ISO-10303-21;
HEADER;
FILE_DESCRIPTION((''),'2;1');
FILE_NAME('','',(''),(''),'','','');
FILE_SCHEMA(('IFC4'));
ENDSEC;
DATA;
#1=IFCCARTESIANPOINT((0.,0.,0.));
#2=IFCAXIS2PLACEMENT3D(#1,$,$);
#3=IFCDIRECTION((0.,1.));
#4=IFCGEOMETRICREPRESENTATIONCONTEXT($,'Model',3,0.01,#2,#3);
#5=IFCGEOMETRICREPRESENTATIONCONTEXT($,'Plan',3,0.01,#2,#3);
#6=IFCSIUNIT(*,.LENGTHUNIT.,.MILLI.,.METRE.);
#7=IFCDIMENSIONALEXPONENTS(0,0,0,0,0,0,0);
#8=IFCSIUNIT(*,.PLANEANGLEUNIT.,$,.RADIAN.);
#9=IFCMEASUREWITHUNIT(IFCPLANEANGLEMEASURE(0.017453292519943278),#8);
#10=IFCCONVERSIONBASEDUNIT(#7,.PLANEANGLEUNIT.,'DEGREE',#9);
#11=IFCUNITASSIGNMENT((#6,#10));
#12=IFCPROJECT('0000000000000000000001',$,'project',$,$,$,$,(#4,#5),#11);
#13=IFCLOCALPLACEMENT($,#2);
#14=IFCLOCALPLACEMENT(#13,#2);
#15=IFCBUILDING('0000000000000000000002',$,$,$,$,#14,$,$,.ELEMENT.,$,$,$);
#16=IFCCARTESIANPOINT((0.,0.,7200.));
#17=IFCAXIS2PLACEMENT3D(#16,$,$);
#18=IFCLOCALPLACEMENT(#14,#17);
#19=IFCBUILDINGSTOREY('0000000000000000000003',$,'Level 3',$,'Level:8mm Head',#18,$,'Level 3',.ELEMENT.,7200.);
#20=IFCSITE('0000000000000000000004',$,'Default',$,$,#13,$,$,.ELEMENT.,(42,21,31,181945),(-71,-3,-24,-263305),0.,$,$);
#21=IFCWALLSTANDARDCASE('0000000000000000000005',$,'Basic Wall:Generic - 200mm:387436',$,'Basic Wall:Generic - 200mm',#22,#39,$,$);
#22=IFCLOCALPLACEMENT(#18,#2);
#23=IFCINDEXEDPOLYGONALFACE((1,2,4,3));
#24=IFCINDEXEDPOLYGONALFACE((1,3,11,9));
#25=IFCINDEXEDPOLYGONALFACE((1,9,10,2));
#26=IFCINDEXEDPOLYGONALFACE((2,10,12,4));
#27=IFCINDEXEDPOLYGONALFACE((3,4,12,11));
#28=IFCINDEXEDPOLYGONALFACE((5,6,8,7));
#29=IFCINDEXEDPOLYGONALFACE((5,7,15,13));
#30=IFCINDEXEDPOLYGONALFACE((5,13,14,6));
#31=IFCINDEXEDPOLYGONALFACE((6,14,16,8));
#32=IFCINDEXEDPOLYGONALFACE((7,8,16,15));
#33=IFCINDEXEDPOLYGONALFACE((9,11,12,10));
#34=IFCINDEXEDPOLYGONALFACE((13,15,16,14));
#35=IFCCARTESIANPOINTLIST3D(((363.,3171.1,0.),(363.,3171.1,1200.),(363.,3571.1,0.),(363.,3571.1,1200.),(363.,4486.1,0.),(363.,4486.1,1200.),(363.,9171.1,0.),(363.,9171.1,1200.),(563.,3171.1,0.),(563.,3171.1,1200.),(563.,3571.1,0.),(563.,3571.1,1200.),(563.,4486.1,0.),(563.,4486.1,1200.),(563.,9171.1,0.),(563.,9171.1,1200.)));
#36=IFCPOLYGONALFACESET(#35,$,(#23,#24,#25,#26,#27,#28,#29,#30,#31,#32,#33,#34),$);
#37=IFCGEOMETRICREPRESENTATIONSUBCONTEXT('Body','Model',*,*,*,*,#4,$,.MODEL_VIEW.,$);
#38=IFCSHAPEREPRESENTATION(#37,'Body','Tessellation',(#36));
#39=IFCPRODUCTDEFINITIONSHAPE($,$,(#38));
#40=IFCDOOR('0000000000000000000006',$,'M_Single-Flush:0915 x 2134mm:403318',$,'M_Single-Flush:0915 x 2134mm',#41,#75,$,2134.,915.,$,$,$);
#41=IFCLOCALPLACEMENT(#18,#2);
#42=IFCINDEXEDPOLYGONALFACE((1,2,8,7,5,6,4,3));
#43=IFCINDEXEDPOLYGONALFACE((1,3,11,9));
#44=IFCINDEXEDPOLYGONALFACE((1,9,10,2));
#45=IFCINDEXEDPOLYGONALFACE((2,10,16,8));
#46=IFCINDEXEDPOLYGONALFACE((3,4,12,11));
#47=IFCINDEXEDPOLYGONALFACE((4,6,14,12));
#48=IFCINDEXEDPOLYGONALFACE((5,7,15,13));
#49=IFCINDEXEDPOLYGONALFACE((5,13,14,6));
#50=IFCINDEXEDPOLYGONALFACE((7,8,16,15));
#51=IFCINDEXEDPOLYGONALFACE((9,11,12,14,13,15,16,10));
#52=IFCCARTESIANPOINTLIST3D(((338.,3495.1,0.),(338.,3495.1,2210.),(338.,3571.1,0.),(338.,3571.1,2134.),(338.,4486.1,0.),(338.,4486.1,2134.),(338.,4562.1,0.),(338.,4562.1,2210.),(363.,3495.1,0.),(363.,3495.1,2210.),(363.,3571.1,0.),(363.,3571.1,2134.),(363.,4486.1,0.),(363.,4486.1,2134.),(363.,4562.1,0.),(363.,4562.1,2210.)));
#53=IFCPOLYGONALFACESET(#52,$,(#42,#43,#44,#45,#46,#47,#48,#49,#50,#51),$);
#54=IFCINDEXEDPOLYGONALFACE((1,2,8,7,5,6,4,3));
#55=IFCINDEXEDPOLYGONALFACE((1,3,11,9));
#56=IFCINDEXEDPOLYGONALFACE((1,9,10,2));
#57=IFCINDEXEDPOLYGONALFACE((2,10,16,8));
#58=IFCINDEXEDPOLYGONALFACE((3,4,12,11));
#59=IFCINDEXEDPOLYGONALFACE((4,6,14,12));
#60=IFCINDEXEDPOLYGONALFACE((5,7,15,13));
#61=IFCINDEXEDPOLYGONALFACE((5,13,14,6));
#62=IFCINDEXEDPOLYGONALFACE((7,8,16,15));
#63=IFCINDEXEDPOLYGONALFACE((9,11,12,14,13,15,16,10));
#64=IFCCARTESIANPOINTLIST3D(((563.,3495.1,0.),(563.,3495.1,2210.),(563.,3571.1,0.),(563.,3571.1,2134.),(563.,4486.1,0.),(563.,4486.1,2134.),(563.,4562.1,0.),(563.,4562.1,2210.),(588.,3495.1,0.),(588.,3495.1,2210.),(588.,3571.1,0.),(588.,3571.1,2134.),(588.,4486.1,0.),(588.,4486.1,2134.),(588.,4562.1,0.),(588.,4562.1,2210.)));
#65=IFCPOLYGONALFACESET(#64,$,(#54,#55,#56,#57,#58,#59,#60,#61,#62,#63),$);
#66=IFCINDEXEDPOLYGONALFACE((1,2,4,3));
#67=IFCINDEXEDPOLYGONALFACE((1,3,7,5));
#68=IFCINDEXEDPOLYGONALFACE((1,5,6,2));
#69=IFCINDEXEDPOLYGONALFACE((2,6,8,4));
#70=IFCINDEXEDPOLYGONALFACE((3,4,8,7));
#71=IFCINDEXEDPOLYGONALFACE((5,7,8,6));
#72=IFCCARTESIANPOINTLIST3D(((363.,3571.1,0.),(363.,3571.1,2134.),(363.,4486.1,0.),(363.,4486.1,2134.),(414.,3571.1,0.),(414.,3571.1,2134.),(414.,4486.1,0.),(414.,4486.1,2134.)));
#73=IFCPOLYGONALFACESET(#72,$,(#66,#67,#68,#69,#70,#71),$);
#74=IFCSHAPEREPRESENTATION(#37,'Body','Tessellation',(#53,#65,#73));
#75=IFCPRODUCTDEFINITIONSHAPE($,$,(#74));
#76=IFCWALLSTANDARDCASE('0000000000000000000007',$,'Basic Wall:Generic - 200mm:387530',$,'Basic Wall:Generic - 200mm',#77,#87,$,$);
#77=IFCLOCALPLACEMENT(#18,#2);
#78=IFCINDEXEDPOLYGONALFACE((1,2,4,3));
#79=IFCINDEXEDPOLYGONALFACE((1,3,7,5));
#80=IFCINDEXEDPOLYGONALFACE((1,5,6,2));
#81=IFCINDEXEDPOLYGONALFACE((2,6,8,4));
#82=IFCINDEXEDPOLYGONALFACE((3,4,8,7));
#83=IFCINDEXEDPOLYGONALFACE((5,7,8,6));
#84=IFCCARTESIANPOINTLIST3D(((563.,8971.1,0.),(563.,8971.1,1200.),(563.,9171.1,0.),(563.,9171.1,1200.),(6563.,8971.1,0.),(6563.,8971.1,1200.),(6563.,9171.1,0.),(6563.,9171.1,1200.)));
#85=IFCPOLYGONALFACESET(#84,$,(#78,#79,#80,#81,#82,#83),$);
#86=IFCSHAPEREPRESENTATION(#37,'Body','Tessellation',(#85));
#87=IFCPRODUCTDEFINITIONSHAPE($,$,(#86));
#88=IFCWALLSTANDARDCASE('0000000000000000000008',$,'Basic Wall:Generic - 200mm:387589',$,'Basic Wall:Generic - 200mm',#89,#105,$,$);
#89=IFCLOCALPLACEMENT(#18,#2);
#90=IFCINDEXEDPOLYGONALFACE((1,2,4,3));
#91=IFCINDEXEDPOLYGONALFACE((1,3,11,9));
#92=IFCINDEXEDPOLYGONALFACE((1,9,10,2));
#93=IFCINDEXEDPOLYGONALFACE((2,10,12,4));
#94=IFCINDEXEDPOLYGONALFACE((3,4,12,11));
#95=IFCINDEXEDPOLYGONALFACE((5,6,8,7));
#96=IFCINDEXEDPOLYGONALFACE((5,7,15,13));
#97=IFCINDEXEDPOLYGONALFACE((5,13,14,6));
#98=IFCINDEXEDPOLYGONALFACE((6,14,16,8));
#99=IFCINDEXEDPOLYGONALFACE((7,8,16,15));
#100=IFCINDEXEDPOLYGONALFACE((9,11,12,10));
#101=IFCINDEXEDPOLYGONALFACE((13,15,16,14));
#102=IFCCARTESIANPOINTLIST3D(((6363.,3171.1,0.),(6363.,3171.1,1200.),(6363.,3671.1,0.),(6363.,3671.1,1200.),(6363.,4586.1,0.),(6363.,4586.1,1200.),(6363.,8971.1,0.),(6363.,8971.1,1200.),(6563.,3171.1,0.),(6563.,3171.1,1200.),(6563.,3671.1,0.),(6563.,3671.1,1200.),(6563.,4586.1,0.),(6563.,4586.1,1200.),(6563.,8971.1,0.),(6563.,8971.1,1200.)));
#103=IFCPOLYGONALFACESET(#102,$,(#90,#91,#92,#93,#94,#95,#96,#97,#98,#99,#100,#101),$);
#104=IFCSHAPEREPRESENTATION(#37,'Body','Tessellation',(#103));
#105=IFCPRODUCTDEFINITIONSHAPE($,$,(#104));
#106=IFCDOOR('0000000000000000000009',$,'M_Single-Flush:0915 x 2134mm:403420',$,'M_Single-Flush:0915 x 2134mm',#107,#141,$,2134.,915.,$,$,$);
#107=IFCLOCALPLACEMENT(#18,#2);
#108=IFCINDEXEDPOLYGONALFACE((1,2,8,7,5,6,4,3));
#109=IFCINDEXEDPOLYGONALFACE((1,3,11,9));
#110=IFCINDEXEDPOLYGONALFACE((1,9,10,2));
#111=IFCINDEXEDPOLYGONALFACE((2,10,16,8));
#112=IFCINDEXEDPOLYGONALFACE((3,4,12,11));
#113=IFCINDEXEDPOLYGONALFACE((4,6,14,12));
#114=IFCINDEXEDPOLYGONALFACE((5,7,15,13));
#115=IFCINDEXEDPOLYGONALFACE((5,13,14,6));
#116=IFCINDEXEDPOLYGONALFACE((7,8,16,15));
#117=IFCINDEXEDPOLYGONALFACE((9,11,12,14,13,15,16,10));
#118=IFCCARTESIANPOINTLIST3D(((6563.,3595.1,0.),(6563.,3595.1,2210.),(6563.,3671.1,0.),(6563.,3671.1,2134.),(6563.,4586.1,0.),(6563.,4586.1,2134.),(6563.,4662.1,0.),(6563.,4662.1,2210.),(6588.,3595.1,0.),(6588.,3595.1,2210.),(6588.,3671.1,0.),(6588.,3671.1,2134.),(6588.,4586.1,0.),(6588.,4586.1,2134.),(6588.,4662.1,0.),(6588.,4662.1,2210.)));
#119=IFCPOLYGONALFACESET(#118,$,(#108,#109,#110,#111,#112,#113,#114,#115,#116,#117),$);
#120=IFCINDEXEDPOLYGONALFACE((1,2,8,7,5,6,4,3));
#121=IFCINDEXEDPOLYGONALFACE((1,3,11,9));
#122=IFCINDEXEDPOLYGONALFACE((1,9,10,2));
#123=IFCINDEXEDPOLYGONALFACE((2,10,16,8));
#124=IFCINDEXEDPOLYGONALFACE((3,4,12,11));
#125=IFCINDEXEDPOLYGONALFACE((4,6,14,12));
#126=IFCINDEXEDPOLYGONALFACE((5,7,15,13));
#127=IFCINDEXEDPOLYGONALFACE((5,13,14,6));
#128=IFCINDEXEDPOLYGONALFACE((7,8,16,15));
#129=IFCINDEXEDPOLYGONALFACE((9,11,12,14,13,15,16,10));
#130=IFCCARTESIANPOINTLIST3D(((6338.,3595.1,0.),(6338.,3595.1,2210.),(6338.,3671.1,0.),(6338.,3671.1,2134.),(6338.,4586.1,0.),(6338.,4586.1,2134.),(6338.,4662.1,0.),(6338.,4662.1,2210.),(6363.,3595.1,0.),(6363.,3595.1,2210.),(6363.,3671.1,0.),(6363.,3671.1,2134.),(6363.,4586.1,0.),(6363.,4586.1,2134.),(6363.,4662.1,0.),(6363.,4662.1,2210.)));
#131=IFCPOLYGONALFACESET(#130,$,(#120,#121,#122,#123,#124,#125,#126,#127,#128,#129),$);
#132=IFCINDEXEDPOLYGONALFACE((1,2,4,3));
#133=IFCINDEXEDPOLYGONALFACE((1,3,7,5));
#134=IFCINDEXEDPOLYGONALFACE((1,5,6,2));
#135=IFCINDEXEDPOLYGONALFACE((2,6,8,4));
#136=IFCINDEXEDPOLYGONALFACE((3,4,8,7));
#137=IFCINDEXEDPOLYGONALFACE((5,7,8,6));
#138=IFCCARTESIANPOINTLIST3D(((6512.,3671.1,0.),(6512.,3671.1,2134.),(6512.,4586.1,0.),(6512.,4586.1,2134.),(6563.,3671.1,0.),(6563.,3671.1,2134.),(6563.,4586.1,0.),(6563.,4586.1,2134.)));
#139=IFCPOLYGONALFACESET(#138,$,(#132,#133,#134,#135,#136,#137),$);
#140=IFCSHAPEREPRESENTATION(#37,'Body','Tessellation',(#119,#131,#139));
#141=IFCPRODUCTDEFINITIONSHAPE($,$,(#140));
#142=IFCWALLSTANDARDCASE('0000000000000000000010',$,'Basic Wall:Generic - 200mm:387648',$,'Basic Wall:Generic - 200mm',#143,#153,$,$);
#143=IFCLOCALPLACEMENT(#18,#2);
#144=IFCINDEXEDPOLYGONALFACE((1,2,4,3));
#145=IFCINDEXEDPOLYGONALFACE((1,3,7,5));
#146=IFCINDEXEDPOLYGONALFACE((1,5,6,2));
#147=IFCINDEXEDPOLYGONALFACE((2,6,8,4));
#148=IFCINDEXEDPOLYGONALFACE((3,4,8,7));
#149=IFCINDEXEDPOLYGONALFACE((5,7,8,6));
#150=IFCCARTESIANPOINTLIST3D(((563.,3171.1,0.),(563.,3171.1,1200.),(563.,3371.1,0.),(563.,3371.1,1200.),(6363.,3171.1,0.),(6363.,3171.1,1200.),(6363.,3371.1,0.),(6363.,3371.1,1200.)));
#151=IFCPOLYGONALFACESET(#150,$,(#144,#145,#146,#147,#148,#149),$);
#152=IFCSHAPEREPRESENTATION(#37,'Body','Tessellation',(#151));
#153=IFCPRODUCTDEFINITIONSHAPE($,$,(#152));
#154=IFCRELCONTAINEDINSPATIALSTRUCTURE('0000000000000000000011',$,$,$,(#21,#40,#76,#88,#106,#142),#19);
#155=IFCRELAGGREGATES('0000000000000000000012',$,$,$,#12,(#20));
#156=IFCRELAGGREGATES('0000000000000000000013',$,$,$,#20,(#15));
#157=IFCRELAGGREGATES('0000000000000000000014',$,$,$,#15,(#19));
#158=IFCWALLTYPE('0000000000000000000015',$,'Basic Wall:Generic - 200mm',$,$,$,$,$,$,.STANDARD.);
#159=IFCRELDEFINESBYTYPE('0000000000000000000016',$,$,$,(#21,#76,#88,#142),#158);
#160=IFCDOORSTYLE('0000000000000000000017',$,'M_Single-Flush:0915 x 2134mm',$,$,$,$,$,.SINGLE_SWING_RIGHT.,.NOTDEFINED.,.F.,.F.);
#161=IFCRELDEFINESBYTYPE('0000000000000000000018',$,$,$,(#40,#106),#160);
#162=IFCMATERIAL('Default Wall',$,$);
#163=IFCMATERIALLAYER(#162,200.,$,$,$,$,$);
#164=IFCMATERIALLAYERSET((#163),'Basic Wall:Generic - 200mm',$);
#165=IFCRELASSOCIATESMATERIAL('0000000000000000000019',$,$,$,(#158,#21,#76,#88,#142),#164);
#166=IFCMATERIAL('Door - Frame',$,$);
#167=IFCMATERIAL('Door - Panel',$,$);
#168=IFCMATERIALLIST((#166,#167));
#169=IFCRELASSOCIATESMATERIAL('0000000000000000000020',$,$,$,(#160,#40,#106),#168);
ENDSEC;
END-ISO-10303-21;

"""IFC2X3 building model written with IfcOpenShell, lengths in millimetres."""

from ifc_helpers import new_model, entity, si_unit, converted_unit, direction, frame, frame_2d, origin, place, context, subcontext, project, spatial, polyline, rectangle, outline, extrude, clip, halfspace, source, transform, mapped, material, material_list, layer, layer_set, layer_usage, type_object, type_shapes, element, fill, save


model = new_model("IFC2X3")

# Units and contexts
model_context = context("Model", 3, precision=0.01, world=origin(), true_north=direction((0.0, 1.0)))
plan_context = context("Plan", 3, precision=0.01, world=origin(), true_north=direction((0.0, 1.0)))
body_context = subcontext(model_context, "Body", "Model", "MODEL_VIEW")
ifc_project = project(units=[si_unit("LENGTHUNIT", "METRE", prefix="MILLI"), converted_unit("PLANEANGLEUNIT", "DEGREE", entity("IfcPlaneAngleMeasure", 0.017453292519943278), si_unit("PLANEANGLEUNIT", "RADIAN"), dimensions=[0, 0, 0, 0, 0, 0, 0])], contexts=[model_context, plan_context])

# Site, building, storey
site_placement = place(None, origin())
site = spatial("IfcSite", under=ifc_project, at=site_placement, Name="Default", CompositionType="ELEMENT", RefLatitude=(42, 21, 31, 181945), RefLongitude=(-71, -3, -24, -263305), RefElevation=0.0)
building_placement = place(site_placement, origin())
building = spatial("IfcBuilding", under=site, at=building_placement, CompositionType="ELEMENT")
storey_placement = place(building_placement, frame((0.0, 0.0, 7200.0)))
storey = spatial("IfcBuildingStorey", under=building, at=storey_placement, Name="Level 3", ObjectType="Level:8mm Head", LongName="Level 3", CompositionType="ELEMENT", Elevation=7200.0)

# Shared definitions
ifc_material_1 = material(Name="Default Wall")
ifc_layer_1 = layer(ifc_material_1, 200.0)
ifc_layer_set_1 = layer_set([ifc_layer_1], Name="Basic Wall:Generic - 200mm")
wall_type = type_object("IfcWallType", Name="Basic Wall:Generic - 200mm", PredefinedType="STANDARD", material=ifc_layer_set_1)

# Wall, opening, door
ifc_layer_usage_1 = layer_usage(ifc_layer_set_1, "AXIS2", "NEGATIVE", 100.0)
wall_1_placement = place(storey_placement, frame((463.0, 3171.1, 0.0), z_axis=(0.0, 0.0, 1.0), x_axis=(0.0, 1.0, 0.0)))
wall_1 = element("IfcWallStandardCase", 1, at=wall_1_placement, inside=storey, type_object=wall_type, material=ifc_layer_usage_1, Name="Basic Wall:Generic - 200mm:387436", ObjectType="Basic Wall:Generic - 200mm", context=body_context, shape_type="Clipping", body=[
    clip(extrude(rectangle(XDim=6000.0, YDim=200.0, at=frame_2d((3000.0, 0.0), x_axis=(1.0, 0.0))), origin(), (0.0, 0.0, 1.0), 1200.0), halfspace(origin(), True)),
])
opening_1_placement = place(wall_1_placement, frame((400.0, -100.0, 0.0)))
opening_1 = element("IfcOpeningElement", 2, at=opening_1_placement, cuts=wall_1, ObjectType="Opening", context=body_context, shape_type="SweptSolid", body=[
    extrude(rectangle(XDim=915.0, YDim=2134.0, at=frame_2d((1067.0, 457.5), x_axis=(0.0, 1.0))), frame((0.0, 0.0, 0.0), z_axis=(0.0, 1.0, 0.0), x_axis=(0.0, 0.0, 1.0)), (0.0, 0.0, 1.0), 200.0),
])
ifc_material_2 = material(Name="Door - Frame")
ifc_material_3 = material(Name="Door - Panel")
ifc_material_list = material_list([ifc_material_2, ifc_material_3])
door_style = type_object("IfcDoorStyle", Name="M_Single-Flush:0915 x 2134mm", ConstructionType="NOTDEFINED", OperationType="SINGLE_SWING_RIGHT", ParameterTakesPrecedence=False, Sizeable=False, material=ifc_material_list)
shared_shape = source(origin(), body_context, "Body", "SweptSolid", [
    extrude(outline(polyline([(-533.5, -1124.0), (533.5, -1124.0), (533.5, 1086.0), (457.5, 1086.0), (457.5, -1048.0), (-457.5, -1048.0), (-457.5, 1086.0), (-533.5, 1086.0), (-533.5, -1124.0)])), frame((457.5, 200.0, 1086.0), z_axis=(0.0, 1.0, 0.0), x_axis=(1.0, 0.0, 0.0)), (0.0, 0.0, 1.0), 25.0),
    extrude(outline(polyline([(-1124.0, -533.5), (1086.0, -533.5), (1086.0, -457.5), (-1048.0, -457.5), (-1048.0, 457.5), (1086.0, 457.5), (1086.0, 533.5), (-1124.0, 533.5), (-1124.0, -533.5)])), frame((457.5, -25.0, 1086.0), z_axis=(0.0, 1.0, 0.0), x_axis=(0.0, 0.0, -1.0)), (0.0, 0.0, 1.0), 25.0),
    extrude(rectangle(XDim=51.0, YDim=915.0, at=frame_2d((0.0, 0.0), x_axis=(1.0, 0.0))), frame((457.5, 174.5, 0.0), z_axis=(0.0, 0.0, 1.0), x_axis=(0.0, 1.0, 0.0)), (0.0, 0.0, 1.0), 2134.0),
])
type_shapes(door_style, [shared_shape])
door_1_placement = place(opening_1_placement, origin())
door_1 = element("IfcDoor", 3, at=door_1_placement, inside=storey, type_object=door_style, material=ifc_material_list, Name="M_Single-Flush:0915 x 2134mm:403318", ObjectType="M_Single-Flush:0915 x 2134mm", OverallHeight=2134.0, OverallWidth=915.0, context=body_context, shape_type="MappedRepresentation", body=[
    mapped(shared_shape, transform((0.0, 0.0, 0.0), scale=1.0)),
])
fill(opening_1, door_1)

# Wall
ifc_layer_usage_2 = layer_usage(ifc_layer_set_1, "AXIS2", "NEGATIVE", 100.0)
wall_2_placement = place(storey_placement, frame((563.0, 9071.1, 0.0)))
element("IfcWallStandardCase", 4, at=wall_2_placement, inside=storey, type_object=wall_type, material=ifc_layer_usage_2, Name="Basic Wall:Generic - 200mm:387530", ObjectType="Basic Wall:Generic - 200mm", context=body_context, shape_type="Clipping", body=[
    clip(extrude(rectangle(XDim=6000.0, YDim=200.0, at=frame_2d((3000.0, 0.0), x_axis=(-1.0, 0.0))), origin(), (0.0, 0.0, 1.0), 1200.0), halfspace(origin(), True)),
])

# Wall, opening, door
ifc_layer_usage_3 = layer_usage(ifc_layer_set_1, "AXIS2", "NEGATIVE", 100.0)
wall_3_placement = place(storey_placement, frame((6463.0, 8971.1, 0.0), z_axis=(0.0, 0.0, 1.0), x_axis=(0.0, -1.0, 0.0)))
wall_3 = element("IfcWallStandardCase", 5, at=wall_3_placement, inside=storey, type_object=wall_type, material=ifc_layer_usage_3, Name="Basic Wall:Generic - 200mm:387589", ObjectType="Basic Wall:Generic - 200mm", context=body_context, shape_type="Clipping", body=[
    clip(extrude(rectangle(XDim=5800.0, YDim=200.0, at=frame_2d((2900.0, 0.0), x_axis=(1.0, 0.0))), origin(), (0.0, 0.0, 1.0), 1200.0), halfspace(origin(), True)),
])
opening_2_placement = place(wall_3_placement, frame((4385.0, -100.0, 0.0)))
opening_2 = element("IfcOpeningElement", 6, at=opening_2_placement, cuts=wall_3, ObjectType="Opening", context=body_context, shape_type="SweptSolid", body=[
    extrude(rectangle(XDim=915.0, YDim=2134.0, at=frame_2d((1067.0, 457.5), x_axis=(0.0, 1.0))), frame((0.0, 0.0, 0.0), z_axis=(0.0, 1.0, 0.0), x_axis=(0.0, 0.0, 1.0)), (0.0, 0.0, 1.0), 200.0),
])
door_2_placement = place(opening_2_placement, origin())
door_2 = element("IfcDoor", 7, at=door_2_placement, inside=storey, type_object=door_style, material=ifc_material_list, Name="M_Single-Flush:0915 x 2134mm:403420", ObjectType="M_Single-Flush:0915 x 2134mm", OverallHeight=2134.0, OverallWidth=915.0, context=body_context, shape_type="MappedRepresentation", body=[
    mapped(shared_shape, transform((0.0, 0.0, 0.0), scale=1.0)),
])
fill(opening_2, door_2)

# Wall
ifc_layer_usage_4 = layer_usage(ifc_layer_set_1, "AXIS2", "NEGATIVE", 100.0)
wall_4_placement = place(storey_placement, frame((6363.0, 3271.1, 0.0), z_axis=(0.0, 0.0, 1.0), x_axis=(-1.0, 0.0, 0.0)))
element("IfcWallStandardCase", 8, at=wall_4_placement, inside=storey, type_object=wall_type, material=ifc_layer_usage_4, Name="Basic Wall:Generic - 200mm:387648", ObjectType="Basic Wall:Generic - 200mm", context=body_context, shape_type="Clipping", body=[
    clip(extrude(rectangle(XDim=5800.0, YDim=200.0, at=frame_2d((2900.0, 0.0), x_axis=(-1.0, 0.0))), origin(), (0.0, 0.0, 1.0), 1200.0), halfspace(origin(), True)),
])

save(model, "model.ifc")
